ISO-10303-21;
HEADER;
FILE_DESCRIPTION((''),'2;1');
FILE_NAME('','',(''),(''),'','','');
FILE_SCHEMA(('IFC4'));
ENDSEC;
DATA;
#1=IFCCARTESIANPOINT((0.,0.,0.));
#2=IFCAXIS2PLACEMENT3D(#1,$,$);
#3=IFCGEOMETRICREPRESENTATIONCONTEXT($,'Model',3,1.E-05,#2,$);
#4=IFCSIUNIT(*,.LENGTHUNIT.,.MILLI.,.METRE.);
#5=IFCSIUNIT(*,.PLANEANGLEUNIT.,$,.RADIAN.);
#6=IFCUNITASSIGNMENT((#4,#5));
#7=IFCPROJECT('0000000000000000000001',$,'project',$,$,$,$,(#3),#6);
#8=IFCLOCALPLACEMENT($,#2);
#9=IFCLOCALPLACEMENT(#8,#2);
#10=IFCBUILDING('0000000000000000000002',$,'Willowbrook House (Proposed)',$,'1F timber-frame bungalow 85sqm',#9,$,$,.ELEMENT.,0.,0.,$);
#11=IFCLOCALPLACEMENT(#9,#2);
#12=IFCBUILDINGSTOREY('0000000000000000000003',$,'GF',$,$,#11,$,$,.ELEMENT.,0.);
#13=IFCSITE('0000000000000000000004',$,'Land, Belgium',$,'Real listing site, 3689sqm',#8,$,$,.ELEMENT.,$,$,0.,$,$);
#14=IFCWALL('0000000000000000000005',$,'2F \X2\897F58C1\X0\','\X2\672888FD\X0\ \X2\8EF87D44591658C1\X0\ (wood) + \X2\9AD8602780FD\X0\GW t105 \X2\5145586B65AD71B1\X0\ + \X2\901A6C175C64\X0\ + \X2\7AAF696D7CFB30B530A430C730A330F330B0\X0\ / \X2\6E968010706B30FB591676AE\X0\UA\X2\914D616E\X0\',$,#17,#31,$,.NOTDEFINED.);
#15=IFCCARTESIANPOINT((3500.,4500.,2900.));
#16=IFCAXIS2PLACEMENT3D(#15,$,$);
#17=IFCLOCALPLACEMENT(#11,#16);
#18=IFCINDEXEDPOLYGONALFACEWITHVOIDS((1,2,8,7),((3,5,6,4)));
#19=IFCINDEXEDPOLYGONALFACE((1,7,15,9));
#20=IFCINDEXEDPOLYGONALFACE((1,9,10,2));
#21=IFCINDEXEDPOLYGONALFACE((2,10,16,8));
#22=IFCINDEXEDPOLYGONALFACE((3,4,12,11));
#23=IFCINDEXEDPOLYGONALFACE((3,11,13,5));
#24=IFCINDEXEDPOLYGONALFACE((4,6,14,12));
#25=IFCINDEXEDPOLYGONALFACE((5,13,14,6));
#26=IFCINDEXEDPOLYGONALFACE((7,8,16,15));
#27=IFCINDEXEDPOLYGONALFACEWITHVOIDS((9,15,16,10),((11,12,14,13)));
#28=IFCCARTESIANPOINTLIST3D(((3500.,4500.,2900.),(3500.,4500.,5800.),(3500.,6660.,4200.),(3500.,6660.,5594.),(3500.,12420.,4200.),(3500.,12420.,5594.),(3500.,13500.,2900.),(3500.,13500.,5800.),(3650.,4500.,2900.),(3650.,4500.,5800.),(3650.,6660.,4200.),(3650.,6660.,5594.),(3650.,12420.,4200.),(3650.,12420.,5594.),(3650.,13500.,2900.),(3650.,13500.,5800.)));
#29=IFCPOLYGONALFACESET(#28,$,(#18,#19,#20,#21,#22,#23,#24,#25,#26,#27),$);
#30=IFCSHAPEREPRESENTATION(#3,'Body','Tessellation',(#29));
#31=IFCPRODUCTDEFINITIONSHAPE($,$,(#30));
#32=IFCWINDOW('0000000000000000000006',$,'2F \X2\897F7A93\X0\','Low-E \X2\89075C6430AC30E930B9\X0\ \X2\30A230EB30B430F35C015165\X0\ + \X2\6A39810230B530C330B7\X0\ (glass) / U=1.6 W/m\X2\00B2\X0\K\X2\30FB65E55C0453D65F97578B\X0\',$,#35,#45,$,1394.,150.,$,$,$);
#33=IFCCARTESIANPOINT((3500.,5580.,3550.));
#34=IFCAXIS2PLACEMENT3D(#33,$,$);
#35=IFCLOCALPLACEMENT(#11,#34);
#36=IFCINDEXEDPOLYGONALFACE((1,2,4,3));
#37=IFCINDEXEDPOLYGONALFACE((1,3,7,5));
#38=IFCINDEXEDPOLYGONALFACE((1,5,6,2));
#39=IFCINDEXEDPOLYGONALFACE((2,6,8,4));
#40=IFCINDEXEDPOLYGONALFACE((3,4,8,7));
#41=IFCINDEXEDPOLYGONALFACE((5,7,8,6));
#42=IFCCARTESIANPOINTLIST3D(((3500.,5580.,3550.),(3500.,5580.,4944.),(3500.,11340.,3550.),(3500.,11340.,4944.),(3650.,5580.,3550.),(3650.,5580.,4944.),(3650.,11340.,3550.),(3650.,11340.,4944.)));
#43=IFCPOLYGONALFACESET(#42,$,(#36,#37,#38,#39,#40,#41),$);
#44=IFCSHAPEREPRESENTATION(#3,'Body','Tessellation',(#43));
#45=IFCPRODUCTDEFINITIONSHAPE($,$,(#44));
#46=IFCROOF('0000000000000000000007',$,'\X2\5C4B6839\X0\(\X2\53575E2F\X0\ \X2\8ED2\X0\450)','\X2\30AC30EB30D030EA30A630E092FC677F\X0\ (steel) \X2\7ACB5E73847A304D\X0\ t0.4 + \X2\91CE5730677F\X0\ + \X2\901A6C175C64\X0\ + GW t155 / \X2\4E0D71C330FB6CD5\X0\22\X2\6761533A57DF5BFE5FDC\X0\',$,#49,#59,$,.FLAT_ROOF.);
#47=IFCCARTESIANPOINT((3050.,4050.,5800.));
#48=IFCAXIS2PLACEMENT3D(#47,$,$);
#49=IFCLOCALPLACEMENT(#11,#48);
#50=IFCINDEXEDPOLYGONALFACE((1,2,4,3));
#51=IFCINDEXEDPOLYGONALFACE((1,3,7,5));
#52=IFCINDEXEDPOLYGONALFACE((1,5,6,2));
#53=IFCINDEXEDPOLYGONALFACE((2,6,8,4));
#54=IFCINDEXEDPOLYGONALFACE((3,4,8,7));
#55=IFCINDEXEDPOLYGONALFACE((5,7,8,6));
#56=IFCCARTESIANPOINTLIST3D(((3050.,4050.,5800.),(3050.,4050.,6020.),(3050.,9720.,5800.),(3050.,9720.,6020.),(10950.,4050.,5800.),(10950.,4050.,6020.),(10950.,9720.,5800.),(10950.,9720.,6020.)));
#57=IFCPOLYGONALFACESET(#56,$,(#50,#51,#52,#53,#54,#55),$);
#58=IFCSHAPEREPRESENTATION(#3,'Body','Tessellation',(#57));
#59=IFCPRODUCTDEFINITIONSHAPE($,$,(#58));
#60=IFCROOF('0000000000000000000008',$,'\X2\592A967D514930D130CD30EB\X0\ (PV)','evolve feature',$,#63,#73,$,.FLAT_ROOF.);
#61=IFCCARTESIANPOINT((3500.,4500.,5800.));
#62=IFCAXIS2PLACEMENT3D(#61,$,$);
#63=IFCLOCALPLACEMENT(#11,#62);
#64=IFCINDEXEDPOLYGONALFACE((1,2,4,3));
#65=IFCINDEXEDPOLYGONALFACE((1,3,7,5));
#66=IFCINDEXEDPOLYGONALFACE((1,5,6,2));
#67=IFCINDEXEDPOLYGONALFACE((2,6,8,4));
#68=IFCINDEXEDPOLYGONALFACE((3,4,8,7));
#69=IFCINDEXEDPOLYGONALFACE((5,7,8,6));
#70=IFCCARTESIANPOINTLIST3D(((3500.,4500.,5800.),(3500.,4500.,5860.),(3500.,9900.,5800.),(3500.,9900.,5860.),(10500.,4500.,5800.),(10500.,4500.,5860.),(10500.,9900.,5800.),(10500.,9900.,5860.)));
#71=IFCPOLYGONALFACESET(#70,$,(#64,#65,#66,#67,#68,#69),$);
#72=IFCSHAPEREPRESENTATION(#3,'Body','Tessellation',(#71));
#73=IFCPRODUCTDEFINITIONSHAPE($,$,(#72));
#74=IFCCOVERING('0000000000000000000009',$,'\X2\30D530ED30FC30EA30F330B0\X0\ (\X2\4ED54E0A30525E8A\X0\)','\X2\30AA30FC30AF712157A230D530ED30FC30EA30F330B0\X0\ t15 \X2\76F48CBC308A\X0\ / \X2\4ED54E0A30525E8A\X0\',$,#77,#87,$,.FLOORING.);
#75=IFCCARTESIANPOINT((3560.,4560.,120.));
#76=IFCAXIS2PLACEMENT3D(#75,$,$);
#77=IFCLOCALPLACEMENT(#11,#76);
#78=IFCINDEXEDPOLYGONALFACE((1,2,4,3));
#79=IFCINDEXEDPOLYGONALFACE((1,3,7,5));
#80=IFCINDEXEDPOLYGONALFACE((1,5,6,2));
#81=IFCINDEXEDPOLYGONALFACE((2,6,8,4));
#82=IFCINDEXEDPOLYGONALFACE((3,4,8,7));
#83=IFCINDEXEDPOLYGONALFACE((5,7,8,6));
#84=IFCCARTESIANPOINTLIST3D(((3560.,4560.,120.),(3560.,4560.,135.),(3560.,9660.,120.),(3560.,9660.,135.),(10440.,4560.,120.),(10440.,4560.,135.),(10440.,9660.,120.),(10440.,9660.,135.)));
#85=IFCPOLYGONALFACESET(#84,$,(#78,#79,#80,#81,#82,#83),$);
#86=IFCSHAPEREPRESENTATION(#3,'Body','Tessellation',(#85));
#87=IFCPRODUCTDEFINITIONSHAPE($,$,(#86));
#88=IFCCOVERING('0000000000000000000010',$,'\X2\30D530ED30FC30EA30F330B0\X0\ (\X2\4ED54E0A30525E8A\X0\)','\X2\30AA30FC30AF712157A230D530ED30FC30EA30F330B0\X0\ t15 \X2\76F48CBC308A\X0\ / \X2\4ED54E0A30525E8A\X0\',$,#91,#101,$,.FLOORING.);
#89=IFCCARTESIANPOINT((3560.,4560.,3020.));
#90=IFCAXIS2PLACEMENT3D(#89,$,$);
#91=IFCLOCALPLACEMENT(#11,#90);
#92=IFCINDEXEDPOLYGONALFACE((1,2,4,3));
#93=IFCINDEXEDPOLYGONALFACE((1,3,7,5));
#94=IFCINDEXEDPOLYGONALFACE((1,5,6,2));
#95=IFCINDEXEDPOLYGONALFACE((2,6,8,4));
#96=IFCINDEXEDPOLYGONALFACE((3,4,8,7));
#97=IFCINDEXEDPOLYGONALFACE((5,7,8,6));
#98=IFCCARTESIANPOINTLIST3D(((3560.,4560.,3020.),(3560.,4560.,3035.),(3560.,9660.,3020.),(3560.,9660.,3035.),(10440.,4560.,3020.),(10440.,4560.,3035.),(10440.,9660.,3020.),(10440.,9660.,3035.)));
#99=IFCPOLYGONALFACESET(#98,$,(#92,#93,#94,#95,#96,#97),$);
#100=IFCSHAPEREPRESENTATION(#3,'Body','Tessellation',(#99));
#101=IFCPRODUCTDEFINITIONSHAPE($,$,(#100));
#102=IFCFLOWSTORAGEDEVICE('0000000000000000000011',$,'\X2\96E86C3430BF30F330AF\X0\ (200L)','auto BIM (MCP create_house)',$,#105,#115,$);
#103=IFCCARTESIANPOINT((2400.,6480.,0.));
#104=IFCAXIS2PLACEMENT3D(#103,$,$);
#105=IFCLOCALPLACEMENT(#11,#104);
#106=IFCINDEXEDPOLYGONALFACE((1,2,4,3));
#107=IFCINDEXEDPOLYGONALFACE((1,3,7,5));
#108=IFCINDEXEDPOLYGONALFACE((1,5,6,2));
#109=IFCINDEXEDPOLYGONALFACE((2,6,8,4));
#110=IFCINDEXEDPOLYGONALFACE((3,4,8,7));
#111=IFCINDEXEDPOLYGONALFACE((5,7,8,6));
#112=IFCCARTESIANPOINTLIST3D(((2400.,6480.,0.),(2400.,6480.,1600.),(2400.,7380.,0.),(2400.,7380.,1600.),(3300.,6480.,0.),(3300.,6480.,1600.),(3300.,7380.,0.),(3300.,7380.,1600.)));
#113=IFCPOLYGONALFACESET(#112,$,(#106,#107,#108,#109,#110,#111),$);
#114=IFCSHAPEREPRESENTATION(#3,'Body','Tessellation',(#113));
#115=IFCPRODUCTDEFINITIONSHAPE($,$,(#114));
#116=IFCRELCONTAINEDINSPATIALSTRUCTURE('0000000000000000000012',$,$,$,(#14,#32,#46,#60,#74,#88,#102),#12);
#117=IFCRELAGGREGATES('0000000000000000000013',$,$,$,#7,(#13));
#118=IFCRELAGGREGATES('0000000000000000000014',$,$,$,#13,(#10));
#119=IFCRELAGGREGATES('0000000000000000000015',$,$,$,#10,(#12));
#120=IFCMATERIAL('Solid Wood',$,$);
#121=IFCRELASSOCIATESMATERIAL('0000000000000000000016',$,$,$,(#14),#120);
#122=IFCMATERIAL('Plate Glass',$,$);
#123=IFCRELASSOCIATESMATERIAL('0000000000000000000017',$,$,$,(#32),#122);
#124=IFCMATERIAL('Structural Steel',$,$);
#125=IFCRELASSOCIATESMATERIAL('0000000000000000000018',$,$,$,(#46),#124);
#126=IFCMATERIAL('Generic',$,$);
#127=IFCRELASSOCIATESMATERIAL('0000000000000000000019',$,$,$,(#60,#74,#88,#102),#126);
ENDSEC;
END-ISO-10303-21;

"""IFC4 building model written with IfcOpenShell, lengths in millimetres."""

from ifc_helpers import new_model, si_unit, frame, frame_2d, origin, place, context, project, spatial, rectangle, extrude, material, element, fill, save


model = new_model("IFC4")

# Units and contexts
model_context = context("Model", 3, precision=1e-05, world=origin())
ifc_project = project(units=[si_unit("LENGTHUNIT", "METRE", prefix="MILLI"), si_unit("PLANEANGLEUNIT", "RADIAN")], contexts=[model_context])

# Site, building, storey
site_placement = place(None, origin())
site = spatial("IfcSite", under=ifc_project, at=site_placement, Name="Land, Belgium", ObjectType="Real listing site, 3689sqm", CompositionType="ELEMENT", RefElevation=0.0)
building_placement = place(site_placement, origin())
building = spatial("IfcBuilding", under=site, at=building_placement, Name="Willowbrook House (Proposed)", ObjectType="1F timber-frame bungalow 85sqm", CompositionType="ELEMENT", ElevationOfRefHeight=0.0, ElevationOfTerrain=0.0)
storey_placement = place(building_placement, origin())
storey = spatial("IfcBuildingStorey", under=building, at=storey_placement, Name="GF", CompositionType="ELEMENT", Elevation=0.0)

# Shared definitions
ifc_material_1 = material(Name="Solid Wood")
ifc_material_2 = material(Name="Generic")

# Shared definitions
ifc_material_3 = material(Name="Plate Glass")

# Wall, opening, window
wall_1_placement = place(storey_placement, frame((3500.0, 4500.0, 2900.0)))
wall_1 = element("IfcWall", 1, at=wall_1_placement, inside=storey, material=ifc_material_1, Name="2F 西壁", Description="木製 軸組外壁 (wood) + 高性能GW t105 充填断熱 + 通気層 + 窯業系サイディング / 準耐火・外皮UA配慮", PredefinedType="NOTDEFINED", context=model_context, shape_type="SweptSolid", body=[
    extrude(rectangle(XDim=150.0, YDim=9000.0, at=frame_2d((75.0, 4500.0))), frame((3500.0, 4500.0, 2900.0)), (0.0, 0.0, 1.0), 2900.0),
])
opening_1_placement = place(storey_placement, frame((3500.0, 5580.0, 3550.0)))
opening_1 = element("IfcOpeningElement", 2, at=opening_1_placement, cuts=wall_1, PredefinedType="NOTDEFINED", context=model_context, shape_type="SweptSolid", body=[
    extrude(rectangle(XDim=150.0, YDim=5760.0, at=frame_2d((75.0, 2880.0))), frame((3500.0, 5580.0, 3550.0)), (0.0, 0.0, 1.0), 1394.0),
])
window_1_placement = place(storey_placement, frame((3500.0, 5580.0, 3550.0)))
window_1 = element("IfcWindow", 3, at=window_1_placement, inside=storey, material=ifc_material_3, Name="2F 西窓", Description="Low-E 複層ガラス アルゴン封入 + 樹脂サッシ (glass) / U=1.6 W/m²K・日射取得型", OverallHeight=1394.0, OverallWidth=150.0, context=model_context, shape_type="SweptSolid", body=[
    extrude(rectangle(XDim=150.0, YDim=5760.0, at=frame_2d((75.0, 2880.0))), frame((3500.0, 5580.0, 3550.0)), (0.0, 0.0, 1.0), 1394.0),
])
fill(opening_1, window_1)

# Roofs
ifc_material_4 = material(Name="Structural Steel")
for number, where, name in (
    (4, (3050.0, 4050.0, 5800.0), "屋根(南帯 軒450)"),
):
    element("IfcRoof", number, at=place(storey_placement, frame(where)), inside=storey, material=ifc_material_4, Name=name, Description="ガルバリウム鋼板 (steel) 立平葺き t0.4 + 野地板 + 通気層 + GW t155 / 不燃・法22条区域対応", PredefinedType="FLAT_ROOF", context=model_context, shape_type="SweptSolid", body=[
        extrude(rectangle(XDim=7900.0, YDim=5670.0, at=frame_2d((3950.0, 2835.0))), frame((3050.0, 4050.0, 5800.0)), (0.0, 0.0, 1.0), 220.0),
    ])
roof_placement = place(storey_placement, frame((3500.0, 4500.0, 5800.0)))
element("IfcRoof", 5, at=roof_placement, inside=storey, material=ifc_material_2, Name="太陽光パネル (PV)", Description="evolve feature", PredefinedType="FLAT_ROOF", context=model_context, shape_type="SweptSolid", body=[
    extrude(rectangle(XDim=7000.0, YDim=5400.0, at=frame_2d((3500.0, 2700.0))), frame((3500.0, 4500.0, 5800.0)), (0.0, 0.0, 1.0), 60.0),
])

# Coverings
covering_1_placement = place(storey_placement, frame((3560.0, 4560.0, 120.0)))
element("IfcCovering", 6, at=covering_1_placement, inside=storey, material=ifc_material_2, Name="フローリング (仕上げ床)", Description="オーク無垢フローリング t15 直貼り / 仕上げ床", PredefinedType="FLOORING", context=model_context, shape_type="SweptSolid", body=[
    extrude(rectangle(XDim=6880.0, YDim=5100.0, at=frame_2d((3440.0, 2550.0))), frame((3560.0, 4560.0, 120.0)), (0.0, 0.0, 1.0), 15.0),
])
covering_2_placement = place(storey_placement, frame((3560.0, 4560.0, 3020.0)))
element("IfcCovering", 7, at=covering_2_placement, inside=storey, material=ifc_material_2, Name="フローリング (仕上げ床)", Description="オーク無垢フローリング t15 直貼り / 仕上げ床", PredefinedType="FLOORING", context=model_context, shape_type="SweptSolid", body=[
    extrude(rectangle(XDim=6880.0, YDim=5100.0, at=frame_2d((3440.0, 2550.0))), frame((3560.0, 4560.0, 3020.0)), (0.0, 0.0, 1.0), 15.0),
])

# Flow storage device
flow_storage_device_placement = place(storey_placement, frame((2400.0, 6480.0, 0.0)))
element("IfcFlowStorageDevice", 8, at=flow_storage_device_placement, inside=storey, material=ifc_material_2, Name="雨水タンク (200L)", Description="auto BIM (MCP create_house)", context=model_context, shape_type="SweptSolid", body=[
    extrude(rectangle(XDim=900.0, YDim=900.0, at=frame_2d((450.0, 450.0))), frame((2400.0, 6480.0, 0.0)), (0.0, 0.0, 1.0), 1600.0),
])

save(model, "model.ifc")
